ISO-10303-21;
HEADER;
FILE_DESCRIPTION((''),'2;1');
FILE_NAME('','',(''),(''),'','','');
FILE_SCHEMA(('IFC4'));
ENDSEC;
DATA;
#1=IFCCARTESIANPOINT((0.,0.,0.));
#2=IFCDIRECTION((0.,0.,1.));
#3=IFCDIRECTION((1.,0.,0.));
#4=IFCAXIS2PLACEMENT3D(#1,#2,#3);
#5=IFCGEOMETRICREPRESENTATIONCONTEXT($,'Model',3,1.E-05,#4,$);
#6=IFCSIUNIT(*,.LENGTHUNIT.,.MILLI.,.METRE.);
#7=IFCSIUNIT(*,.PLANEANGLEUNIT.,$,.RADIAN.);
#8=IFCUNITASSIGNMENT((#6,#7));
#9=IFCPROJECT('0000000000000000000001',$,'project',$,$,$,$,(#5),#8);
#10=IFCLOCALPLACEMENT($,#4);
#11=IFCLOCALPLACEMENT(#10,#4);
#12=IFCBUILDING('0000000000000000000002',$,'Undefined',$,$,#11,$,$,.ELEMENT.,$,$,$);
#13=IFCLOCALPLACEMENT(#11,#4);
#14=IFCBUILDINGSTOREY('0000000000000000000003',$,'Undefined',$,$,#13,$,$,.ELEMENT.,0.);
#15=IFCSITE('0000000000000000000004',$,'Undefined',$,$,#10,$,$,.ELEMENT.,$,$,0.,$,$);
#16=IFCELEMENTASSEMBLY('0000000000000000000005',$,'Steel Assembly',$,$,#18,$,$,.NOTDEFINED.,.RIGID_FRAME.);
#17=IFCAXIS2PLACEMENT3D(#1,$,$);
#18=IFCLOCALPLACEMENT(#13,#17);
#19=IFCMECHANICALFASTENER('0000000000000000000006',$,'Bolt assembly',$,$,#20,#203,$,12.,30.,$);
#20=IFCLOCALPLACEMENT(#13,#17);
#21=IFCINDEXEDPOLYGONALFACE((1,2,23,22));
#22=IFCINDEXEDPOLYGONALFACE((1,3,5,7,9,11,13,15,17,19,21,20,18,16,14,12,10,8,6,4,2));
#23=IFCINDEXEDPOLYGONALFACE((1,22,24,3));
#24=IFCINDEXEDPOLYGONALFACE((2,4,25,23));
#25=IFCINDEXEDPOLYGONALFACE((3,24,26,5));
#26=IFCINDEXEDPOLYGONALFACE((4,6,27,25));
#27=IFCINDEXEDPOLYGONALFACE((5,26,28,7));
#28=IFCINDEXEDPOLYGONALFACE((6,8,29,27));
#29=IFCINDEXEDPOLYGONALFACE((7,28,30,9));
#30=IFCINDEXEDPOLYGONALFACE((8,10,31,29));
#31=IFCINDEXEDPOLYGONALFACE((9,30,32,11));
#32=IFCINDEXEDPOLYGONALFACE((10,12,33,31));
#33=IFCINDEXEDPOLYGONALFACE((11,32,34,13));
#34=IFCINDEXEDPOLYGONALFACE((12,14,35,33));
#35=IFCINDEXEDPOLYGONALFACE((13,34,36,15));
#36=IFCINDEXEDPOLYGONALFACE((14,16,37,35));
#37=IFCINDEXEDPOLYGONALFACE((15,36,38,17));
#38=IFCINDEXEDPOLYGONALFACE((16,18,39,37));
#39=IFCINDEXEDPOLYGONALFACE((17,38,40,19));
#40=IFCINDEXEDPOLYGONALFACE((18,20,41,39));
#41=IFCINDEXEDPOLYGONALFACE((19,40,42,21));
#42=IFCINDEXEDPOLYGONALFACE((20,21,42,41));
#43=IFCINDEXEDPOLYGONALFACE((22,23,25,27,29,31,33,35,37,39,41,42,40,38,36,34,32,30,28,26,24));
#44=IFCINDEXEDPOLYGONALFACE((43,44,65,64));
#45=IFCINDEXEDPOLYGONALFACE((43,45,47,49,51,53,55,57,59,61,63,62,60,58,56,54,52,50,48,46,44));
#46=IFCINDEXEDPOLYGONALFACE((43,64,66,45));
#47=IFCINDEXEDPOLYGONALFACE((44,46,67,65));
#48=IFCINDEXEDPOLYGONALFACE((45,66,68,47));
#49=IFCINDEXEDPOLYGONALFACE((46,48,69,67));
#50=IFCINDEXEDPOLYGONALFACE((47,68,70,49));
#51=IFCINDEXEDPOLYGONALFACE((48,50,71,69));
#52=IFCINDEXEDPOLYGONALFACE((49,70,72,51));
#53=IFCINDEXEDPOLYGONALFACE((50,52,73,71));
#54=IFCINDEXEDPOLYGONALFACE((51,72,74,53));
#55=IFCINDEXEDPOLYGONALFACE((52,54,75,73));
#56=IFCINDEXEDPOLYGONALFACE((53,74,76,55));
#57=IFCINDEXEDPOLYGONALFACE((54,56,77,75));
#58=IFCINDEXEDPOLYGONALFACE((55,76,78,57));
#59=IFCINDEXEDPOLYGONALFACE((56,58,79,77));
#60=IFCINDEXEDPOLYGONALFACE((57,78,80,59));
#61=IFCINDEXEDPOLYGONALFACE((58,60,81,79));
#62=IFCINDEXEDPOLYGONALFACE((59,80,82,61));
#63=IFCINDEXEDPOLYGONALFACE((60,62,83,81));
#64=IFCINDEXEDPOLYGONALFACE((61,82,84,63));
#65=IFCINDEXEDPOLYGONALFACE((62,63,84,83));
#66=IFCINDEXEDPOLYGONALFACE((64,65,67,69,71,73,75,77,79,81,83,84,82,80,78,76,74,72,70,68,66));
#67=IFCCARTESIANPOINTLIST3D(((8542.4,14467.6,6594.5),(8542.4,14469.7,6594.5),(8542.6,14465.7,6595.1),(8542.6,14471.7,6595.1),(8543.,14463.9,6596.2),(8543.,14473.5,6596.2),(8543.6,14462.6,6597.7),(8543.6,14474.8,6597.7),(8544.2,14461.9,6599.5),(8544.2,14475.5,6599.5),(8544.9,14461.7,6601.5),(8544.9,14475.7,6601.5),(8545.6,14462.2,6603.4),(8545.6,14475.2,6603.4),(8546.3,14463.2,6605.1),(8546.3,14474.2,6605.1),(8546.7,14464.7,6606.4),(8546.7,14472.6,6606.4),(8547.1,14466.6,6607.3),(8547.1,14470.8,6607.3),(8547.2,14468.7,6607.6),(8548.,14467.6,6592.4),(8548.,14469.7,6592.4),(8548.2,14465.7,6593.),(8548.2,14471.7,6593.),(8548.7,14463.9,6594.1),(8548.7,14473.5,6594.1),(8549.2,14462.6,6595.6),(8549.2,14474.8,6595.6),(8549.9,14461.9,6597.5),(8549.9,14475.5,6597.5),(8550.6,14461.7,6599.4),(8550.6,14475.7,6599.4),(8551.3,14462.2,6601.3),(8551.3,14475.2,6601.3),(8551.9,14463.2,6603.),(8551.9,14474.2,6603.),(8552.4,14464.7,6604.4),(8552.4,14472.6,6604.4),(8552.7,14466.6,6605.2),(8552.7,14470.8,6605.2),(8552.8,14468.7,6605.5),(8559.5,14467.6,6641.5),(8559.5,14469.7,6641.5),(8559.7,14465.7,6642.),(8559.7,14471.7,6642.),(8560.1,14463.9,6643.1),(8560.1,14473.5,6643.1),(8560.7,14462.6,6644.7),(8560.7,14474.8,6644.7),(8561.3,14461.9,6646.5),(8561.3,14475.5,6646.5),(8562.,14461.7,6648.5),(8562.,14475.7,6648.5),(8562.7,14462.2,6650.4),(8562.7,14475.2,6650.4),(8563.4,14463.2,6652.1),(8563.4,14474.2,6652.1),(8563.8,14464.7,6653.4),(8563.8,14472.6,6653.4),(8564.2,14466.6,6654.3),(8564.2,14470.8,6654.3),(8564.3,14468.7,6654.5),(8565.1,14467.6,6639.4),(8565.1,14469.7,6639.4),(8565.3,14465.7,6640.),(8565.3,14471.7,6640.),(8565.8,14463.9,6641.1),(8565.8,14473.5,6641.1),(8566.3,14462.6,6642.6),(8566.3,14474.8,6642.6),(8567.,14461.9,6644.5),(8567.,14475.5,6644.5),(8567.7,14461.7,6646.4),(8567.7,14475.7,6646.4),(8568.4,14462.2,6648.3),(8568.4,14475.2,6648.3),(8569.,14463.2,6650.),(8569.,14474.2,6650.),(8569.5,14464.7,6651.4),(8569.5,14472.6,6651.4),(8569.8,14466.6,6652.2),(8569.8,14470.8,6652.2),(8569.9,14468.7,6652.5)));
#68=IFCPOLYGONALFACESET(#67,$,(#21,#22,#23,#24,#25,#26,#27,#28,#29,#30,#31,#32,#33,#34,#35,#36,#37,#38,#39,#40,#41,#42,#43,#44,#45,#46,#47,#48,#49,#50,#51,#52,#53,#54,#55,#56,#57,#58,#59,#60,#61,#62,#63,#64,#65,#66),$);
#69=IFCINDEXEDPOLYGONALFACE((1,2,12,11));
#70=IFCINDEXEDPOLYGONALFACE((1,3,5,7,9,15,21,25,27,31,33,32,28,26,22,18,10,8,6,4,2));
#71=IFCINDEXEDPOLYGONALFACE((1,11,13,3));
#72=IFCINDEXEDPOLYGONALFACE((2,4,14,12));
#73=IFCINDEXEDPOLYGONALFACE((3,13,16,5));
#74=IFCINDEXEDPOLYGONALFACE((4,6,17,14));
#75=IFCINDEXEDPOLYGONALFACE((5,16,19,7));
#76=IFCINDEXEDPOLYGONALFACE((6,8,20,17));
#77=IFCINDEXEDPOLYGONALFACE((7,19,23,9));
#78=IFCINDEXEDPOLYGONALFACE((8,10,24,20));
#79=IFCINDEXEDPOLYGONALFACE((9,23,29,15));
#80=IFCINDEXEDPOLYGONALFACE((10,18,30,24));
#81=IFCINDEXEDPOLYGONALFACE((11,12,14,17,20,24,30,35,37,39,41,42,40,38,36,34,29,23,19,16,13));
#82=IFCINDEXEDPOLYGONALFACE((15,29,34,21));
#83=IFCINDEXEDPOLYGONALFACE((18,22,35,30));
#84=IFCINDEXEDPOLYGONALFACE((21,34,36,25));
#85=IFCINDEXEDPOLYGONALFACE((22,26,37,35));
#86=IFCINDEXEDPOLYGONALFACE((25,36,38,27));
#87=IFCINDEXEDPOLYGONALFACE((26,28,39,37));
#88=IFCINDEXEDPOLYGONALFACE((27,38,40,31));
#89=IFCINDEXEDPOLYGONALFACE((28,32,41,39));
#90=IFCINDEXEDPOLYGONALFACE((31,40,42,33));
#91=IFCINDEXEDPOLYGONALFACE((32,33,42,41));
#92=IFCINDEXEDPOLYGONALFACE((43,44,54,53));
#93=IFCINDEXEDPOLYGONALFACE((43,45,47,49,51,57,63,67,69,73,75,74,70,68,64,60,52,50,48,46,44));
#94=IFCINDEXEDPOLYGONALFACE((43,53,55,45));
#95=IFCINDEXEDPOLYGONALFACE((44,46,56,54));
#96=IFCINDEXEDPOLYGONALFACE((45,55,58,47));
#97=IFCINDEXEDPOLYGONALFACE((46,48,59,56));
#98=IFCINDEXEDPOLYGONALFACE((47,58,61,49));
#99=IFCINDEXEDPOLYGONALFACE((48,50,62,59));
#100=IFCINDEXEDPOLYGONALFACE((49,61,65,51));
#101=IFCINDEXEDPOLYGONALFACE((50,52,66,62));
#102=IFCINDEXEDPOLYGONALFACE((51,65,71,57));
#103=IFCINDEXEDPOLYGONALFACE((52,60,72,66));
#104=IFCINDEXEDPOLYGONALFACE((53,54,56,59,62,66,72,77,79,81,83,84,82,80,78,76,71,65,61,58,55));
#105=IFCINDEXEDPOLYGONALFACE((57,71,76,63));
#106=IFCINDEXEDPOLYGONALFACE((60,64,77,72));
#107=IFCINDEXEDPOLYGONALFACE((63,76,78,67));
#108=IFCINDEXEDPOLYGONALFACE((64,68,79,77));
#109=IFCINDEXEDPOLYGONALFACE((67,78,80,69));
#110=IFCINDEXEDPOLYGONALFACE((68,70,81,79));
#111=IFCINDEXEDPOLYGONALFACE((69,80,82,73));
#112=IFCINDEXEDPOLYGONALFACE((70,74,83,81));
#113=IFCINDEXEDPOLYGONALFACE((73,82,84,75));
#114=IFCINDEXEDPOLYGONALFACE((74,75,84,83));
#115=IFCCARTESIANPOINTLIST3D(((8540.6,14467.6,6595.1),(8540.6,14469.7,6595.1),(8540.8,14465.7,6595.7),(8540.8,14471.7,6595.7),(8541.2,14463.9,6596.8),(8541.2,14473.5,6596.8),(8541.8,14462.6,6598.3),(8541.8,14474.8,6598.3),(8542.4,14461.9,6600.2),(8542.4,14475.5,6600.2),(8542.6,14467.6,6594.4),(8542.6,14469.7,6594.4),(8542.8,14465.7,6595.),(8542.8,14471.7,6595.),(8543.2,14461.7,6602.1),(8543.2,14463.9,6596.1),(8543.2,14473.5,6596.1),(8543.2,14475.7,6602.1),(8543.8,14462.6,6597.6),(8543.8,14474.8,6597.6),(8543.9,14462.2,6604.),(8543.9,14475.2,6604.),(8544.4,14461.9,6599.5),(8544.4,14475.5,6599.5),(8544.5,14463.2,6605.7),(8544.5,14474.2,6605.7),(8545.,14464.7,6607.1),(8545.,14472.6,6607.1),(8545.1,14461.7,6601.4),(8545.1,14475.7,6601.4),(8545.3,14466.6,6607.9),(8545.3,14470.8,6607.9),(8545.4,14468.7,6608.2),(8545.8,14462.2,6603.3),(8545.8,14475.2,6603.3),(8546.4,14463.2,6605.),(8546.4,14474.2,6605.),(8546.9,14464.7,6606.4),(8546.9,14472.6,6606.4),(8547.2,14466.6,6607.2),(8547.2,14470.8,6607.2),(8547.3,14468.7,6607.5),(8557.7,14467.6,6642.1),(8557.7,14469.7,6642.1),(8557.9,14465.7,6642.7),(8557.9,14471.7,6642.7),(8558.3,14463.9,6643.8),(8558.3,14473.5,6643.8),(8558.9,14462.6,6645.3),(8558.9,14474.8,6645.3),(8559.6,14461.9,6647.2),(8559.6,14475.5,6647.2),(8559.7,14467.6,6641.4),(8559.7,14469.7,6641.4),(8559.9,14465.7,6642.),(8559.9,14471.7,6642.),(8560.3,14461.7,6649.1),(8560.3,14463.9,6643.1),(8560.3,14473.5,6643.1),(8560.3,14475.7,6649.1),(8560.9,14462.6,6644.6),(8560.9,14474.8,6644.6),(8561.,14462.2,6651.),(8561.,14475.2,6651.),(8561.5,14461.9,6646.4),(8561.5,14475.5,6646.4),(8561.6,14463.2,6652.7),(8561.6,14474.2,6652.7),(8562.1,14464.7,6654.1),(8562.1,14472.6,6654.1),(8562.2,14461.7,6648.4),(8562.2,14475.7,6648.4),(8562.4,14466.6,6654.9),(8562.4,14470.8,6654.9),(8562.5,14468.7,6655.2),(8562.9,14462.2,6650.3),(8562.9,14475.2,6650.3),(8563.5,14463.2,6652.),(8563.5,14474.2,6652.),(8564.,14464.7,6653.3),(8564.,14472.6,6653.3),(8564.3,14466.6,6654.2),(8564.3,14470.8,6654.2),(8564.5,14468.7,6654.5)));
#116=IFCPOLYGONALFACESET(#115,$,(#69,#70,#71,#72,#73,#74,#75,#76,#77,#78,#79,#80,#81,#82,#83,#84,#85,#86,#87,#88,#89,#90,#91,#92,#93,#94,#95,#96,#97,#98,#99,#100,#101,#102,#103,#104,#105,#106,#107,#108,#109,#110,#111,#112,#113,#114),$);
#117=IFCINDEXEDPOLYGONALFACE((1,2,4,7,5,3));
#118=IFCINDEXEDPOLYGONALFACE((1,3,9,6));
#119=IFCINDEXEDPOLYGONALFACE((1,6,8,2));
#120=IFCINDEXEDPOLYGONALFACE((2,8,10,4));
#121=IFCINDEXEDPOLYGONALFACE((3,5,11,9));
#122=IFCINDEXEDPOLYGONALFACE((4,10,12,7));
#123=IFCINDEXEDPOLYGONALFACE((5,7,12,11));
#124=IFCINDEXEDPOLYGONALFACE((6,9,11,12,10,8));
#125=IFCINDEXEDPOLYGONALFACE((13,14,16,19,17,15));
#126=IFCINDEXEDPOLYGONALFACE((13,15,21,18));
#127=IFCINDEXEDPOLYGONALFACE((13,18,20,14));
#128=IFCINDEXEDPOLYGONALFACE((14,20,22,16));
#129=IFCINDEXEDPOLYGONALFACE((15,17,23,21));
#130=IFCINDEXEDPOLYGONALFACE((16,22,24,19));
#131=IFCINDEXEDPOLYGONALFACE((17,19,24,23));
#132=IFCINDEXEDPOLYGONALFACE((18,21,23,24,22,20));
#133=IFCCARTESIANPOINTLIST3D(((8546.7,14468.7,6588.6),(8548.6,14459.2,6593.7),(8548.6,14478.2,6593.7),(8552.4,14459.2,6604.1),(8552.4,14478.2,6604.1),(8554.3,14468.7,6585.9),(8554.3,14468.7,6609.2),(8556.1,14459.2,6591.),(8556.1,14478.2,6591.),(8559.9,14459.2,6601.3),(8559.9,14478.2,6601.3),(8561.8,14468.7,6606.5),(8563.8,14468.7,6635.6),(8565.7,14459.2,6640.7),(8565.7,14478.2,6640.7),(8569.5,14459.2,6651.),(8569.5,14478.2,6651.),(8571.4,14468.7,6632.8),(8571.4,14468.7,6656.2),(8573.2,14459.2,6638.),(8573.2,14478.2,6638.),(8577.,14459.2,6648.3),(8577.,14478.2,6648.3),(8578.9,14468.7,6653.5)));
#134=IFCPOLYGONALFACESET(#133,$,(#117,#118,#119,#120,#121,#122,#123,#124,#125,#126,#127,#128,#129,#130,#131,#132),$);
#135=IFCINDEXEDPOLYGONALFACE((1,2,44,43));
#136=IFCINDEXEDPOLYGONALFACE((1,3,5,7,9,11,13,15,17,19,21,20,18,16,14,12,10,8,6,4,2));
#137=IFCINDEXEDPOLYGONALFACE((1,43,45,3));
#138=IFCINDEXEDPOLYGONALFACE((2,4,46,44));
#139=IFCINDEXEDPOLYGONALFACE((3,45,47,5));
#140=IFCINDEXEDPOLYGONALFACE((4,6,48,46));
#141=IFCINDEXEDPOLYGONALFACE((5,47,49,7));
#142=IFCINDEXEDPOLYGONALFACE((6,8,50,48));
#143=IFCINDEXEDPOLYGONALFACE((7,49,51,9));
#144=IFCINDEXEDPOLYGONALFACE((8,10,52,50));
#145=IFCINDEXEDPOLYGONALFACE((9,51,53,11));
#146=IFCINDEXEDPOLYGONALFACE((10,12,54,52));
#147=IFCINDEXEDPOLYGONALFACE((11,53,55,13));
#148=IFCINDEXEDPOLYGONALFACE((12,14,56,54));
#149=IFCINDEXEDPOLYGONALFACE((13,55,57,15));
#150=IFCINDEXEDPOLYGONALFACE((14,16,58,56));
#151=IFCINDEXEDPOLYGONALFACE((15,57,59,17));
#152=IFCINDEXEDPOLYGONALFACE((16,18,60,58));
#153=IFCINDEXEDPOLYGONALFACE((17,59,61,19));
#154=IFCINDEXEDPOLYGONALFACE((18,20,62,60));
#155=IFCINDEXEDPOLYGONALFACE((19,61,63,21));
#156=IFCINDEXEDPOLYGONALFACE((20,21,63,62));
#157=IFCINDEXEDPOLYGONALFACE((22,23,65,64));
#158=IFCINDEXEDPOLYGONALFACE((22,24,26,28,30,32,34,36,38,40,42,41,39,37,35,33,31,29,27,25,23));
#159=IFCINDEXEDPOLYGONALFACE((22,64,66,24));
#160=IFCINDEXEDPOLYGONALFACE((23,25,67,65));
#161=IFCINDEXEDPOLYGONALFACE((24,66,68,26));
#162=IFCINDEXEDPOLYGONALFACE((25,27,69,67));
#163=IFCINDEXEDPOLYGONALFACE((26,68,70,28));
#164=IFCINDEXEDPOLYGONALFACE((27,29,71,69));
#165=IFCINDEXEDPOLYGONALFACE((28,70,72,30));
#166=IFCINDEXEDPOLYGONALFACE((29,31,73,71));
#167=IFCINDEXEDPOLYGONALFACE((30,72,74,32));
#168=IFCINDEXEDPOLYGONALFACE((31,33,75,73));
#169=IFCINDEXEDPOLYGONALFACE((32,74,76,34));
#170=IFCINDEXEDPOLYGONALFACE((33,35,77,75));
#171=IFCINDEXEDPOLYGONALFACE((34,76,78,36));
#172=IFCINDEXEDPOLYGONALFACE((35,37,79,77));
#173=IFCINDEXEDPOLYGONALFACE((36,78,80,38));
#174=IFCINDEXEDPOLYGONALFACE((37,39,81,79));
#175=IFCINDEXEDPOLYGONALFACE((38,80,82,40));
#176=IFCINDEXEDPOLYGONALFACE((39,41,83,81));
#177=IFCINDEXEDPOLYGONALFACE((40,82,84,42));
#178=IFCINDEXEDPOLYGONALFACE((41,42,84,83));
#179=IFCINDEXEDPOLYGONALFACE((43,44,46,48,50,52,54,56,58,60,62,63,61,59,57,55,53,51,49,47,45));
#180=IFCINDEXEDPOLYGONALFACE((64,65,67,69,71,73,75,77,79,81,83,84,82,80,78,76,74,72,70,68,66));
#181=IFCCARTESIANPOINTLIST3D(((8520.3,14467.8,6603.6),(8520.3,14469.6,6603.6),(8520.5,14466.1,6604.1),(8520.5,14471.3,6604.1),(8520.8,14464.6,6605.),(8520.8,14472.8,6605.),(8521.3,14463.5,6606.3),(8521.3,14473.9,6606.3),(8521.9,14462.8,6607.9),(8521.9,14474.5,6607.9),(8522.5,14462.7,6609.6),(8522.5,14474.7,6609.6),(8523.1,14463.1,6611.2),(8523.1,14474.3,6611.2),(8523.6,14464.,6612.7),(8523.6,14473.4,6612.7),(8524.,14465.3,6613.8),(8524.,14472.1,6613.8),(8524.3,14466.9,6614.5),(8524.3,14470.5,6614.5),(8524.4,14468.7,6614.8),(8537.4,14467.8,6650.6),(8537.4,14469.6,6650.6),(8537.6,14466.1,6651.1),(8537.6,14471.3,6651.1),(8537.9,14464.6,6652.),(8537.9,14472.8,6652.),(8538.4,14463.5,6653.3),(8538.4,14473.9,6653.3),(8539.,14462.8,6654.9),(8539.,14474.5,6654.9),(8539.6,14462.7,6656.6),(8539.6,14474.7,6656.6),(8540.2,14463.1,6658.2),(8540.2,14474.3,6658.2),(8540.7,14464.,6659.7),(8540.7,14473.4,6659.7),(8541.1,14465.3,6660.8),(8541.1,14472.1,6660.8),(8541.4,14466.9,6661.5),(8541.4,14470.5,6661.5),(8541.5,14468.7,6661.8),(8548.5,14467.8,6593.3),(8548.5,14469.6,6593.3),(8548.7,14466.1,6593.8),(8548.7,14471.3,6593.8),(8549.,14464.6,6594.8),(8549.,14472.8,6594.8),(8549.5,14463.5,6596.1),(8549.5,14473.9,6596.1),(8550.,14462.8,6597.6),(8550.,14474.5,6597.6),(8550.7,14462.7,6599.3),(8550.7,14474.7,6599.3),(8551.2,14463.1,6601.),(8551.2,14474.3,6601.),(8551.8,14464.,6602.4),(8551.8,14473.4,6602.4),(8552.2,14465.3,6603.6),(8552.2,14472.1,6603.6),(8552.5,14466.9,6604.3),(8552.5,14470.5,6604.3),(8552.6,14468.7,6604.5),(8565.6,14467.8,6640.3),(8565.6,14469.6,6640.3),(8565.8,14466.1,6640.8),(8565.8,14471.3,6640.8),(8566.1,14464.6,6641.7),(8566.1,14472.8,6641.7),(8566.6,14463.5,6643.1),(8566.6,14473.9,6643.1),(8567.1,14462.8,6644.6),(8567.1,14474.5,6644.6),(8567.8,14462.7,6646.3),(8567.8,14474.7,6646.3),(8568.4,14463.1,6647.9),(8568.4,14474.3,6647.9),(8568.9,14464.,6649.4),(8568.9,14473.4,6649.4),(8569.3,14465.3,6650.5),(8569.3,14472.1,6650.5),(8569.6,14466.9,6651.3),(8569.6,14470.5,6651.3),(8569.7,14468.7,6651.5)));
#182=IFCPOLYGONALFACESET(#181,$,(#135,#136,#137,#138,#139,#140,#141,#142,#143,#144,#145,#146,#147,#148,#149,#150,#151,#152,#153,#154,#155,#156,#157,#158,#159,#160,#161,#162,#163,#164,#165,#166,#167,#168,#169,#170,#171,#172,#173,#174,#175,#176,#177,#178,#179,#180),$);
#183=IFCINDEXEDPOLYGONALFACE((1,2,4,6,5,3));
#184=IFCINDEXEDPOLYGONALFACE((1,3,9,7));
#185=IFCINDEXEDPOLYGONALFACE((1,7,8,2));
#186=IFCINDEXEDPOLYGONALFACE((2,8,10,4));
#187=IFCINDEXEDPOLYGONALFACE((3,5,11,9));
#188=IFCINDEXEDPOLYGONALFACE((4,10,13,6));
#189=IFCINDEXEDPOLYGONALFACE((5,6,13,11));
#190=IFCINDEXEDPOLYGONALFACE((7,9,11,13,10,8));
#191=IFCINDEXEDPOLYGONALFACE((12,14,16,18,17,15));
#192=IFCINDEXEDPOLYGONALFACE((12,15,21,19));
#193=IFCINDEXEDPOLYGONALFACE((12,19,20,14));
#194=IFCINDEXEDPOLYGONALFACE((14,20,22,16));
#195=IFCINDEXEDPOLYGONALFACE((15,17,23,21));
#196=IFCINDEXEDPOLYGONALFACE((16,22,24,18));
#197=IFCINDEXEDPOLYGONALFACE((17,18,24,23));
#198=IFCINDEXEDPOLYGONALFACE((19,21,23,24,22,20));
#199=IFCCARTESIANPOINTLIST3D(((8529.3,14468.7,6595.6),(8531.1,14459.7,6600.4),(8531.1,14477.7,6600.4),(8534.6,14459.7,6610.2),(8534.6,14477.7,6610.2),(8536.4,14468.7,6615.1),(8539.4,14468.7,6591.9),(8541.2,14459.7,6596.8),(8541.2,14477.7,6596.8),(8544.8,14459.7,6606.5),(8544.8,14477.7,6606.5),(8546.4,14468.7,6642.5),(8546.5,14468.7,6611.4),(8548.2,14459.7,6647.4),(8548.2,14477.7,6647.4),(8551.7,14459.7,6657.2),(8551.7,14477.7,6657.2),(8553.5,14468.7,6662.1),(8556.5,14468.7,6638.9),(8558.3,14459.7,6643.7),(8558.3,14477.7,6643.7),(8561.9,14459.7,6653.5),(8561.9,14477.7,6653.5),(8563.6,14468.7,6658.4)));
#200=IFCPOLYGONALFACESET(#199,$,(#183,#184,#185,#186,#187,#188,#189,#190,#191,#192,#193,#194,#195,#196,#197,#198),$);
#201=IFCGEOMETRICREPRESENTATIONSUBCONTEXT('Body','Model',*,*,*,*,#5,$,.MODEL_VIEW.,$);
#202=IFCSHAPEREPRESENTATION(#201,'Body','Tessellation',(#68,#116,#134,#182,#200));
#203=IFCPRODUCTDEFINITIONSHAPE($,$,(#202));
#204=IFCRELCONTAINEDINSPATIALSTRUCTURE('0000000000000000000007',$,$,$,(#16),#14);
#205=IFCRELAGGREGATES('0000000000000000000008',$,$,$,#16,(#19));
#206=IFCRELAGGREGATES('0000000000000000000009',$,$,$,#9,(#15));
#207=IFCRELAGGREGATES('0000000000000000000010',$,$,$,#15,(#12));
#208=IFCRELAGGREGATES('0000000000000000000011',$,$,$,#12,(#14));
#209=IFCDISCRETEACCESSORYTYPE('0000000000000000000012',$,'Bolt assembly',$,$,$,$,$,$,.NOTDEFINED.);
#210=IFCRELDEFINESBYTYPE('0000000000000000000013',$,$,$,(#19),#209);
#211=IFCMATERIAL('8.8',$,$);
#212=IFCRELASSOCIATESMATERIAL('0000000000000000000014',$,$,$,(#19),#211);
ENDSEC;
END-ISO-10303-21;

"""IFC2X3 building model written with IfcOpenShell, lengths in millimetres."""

from ifc_helpers import new_model, si_unit, frame, origin_with_axes, origin_2d_with_axis, place, context, subcontext, project, spatial, polyline, circle, outline, extrude, source, transform, mapped, material, type_object, element, aggregate, save


model = new_model("IFC2X3")

# Units and contexts
model_context = context("Model", 3, precision=1e-05, world=origin_with_axes())
body_context = subcontext(model_context, "Body", "Model", "MODEL_VIEW")
ifc_project = project(units=[si_unit("LENGTHUNIT", "METRE", prefix="MILLI"), si_unit("PLANEANGLEUNIT", "RADIAN")], contexts=[model_context])

# Site, building, storey
site_placement = place(None, origin_with_axes())
site = spatial("IfcSite", under=ifc_project, at=site_placement, Name="Undefined", CompositionType="ELEMENT", RefElevation=0.0)
building_placement = place(site_placement, origin_with_axes())
building = spatial("IfcBuilding", under=site, at=building_placement, Name="Undefined", CompositionType="ELEMENT")
storey_placement = place(building_placement, origin_with_axes())
storey = spatial("IfcBuildingStorey", under=building, at=storey_placement, Name="Undefined", CompositionType="ELEMENT", Elevation=0.0)

# Element assembly
assembly_1_placement = place(storey_placement, origin_with_axes())
assembly_1 = element("IfcElementAssembly", 1, at=assembly_1_placement, inside=storey, Name="Steel Assembly", AssemblyPlace="NOTDEFINED", PredefinedType="RIGID_FRAME")

# Shared definitions
ifc_material_1 = material(Name="8.8")
discrete_accessory_type_1 = type_object("IfcDiscreteAccessoryType", Name="Bolt assembly")
shared_shape_1 = source(origin_with_axes(), body_context, "Body", "SweptSolid", [
    extrude(circle(Radius=7.0, at=origin_2d_with_axis()), frame((0.0, -5.9, 0.0), z_axis=(0.0, 1.0, 0.0), x_axis=(1.0, 0.0, 0.0)), (0.0, 0.0, 1.0), 6.0),
    extrude(circle(Radius=7.0, at=origin_2d_with_axis()), frame((0.0, -0.1, 0.0), z_axis=(0.0, 1.0, 0.0), x_axis=(1.0, 0.0, 0.0)), (0.0, 0.0, 1.0), 2.1),
    extrude(outline(polyline([(11.0, 0.0), (5.5, 9.5), (-5.5, 9.5), (-11.0, 0.0), (-5.5, -9.5), (5.5, -9.5), (11.0, 0.0)])), frame((0.0, -14.0, 0.0), z_axis=(0.0, 1.0, 0.0), x_axis=(1.0, 0.0, 0.0)), (0.0, 0.0, 1.0), 8.0),
    extrude(circle(Radius=6.0, at=origin_2d_with_axis()), frame((0.0, -6.0, 0.0), z_axis=(0.0, 1.0, 0.0), x_axis=(1.0, 0.0, 0.0)), (0.0, 0.0, 1.0), 30.0),
    extrude(outline(polyline([(10.4, 0.0), (5.2, 9.0), (-5.2, 9.0), (-10.4, 0.0), (-5.2, -9.0), (5.2, -9.0), (10.4, 0.0)])), frame((0.0, 2.0, 0.0), z_axis=(0.0, 1.0, 0.0), x_axis=(1.0, 0.0, 0.0)), (0.0, 0.0, 1.0), 10.8),
])

# Mechanical fastener
mechanical_fastener_1_placement = place(assembly_1_placement, frame((8544.9, 14468.7, 6601.0), z_axis=(0.0, -1.0, 0.0), x_axis=(0.34202, 0.0, 0.939693)))
mechanical_fastener_1 = element("IfcMechanicalFastener", 2, at=mechanical_fastener_1_placement, type_object=discrete_accessory_type_1, material=ifc_material_1, Name="Bolt assembly", NominalDiameter=12.0, NominalLength=30.0, context=body_context, shape_type="MappedRepresentation", body=[
    mapped(shared_shape_1, transform((0.0, 0.0, 0.0))),
    mapped(shared_shape_1, transform((50.0, 0.0, 0.0))),
])

aggregate(assembly_1, [mechanical_fastener_1])

save(model, "model.ifc")
